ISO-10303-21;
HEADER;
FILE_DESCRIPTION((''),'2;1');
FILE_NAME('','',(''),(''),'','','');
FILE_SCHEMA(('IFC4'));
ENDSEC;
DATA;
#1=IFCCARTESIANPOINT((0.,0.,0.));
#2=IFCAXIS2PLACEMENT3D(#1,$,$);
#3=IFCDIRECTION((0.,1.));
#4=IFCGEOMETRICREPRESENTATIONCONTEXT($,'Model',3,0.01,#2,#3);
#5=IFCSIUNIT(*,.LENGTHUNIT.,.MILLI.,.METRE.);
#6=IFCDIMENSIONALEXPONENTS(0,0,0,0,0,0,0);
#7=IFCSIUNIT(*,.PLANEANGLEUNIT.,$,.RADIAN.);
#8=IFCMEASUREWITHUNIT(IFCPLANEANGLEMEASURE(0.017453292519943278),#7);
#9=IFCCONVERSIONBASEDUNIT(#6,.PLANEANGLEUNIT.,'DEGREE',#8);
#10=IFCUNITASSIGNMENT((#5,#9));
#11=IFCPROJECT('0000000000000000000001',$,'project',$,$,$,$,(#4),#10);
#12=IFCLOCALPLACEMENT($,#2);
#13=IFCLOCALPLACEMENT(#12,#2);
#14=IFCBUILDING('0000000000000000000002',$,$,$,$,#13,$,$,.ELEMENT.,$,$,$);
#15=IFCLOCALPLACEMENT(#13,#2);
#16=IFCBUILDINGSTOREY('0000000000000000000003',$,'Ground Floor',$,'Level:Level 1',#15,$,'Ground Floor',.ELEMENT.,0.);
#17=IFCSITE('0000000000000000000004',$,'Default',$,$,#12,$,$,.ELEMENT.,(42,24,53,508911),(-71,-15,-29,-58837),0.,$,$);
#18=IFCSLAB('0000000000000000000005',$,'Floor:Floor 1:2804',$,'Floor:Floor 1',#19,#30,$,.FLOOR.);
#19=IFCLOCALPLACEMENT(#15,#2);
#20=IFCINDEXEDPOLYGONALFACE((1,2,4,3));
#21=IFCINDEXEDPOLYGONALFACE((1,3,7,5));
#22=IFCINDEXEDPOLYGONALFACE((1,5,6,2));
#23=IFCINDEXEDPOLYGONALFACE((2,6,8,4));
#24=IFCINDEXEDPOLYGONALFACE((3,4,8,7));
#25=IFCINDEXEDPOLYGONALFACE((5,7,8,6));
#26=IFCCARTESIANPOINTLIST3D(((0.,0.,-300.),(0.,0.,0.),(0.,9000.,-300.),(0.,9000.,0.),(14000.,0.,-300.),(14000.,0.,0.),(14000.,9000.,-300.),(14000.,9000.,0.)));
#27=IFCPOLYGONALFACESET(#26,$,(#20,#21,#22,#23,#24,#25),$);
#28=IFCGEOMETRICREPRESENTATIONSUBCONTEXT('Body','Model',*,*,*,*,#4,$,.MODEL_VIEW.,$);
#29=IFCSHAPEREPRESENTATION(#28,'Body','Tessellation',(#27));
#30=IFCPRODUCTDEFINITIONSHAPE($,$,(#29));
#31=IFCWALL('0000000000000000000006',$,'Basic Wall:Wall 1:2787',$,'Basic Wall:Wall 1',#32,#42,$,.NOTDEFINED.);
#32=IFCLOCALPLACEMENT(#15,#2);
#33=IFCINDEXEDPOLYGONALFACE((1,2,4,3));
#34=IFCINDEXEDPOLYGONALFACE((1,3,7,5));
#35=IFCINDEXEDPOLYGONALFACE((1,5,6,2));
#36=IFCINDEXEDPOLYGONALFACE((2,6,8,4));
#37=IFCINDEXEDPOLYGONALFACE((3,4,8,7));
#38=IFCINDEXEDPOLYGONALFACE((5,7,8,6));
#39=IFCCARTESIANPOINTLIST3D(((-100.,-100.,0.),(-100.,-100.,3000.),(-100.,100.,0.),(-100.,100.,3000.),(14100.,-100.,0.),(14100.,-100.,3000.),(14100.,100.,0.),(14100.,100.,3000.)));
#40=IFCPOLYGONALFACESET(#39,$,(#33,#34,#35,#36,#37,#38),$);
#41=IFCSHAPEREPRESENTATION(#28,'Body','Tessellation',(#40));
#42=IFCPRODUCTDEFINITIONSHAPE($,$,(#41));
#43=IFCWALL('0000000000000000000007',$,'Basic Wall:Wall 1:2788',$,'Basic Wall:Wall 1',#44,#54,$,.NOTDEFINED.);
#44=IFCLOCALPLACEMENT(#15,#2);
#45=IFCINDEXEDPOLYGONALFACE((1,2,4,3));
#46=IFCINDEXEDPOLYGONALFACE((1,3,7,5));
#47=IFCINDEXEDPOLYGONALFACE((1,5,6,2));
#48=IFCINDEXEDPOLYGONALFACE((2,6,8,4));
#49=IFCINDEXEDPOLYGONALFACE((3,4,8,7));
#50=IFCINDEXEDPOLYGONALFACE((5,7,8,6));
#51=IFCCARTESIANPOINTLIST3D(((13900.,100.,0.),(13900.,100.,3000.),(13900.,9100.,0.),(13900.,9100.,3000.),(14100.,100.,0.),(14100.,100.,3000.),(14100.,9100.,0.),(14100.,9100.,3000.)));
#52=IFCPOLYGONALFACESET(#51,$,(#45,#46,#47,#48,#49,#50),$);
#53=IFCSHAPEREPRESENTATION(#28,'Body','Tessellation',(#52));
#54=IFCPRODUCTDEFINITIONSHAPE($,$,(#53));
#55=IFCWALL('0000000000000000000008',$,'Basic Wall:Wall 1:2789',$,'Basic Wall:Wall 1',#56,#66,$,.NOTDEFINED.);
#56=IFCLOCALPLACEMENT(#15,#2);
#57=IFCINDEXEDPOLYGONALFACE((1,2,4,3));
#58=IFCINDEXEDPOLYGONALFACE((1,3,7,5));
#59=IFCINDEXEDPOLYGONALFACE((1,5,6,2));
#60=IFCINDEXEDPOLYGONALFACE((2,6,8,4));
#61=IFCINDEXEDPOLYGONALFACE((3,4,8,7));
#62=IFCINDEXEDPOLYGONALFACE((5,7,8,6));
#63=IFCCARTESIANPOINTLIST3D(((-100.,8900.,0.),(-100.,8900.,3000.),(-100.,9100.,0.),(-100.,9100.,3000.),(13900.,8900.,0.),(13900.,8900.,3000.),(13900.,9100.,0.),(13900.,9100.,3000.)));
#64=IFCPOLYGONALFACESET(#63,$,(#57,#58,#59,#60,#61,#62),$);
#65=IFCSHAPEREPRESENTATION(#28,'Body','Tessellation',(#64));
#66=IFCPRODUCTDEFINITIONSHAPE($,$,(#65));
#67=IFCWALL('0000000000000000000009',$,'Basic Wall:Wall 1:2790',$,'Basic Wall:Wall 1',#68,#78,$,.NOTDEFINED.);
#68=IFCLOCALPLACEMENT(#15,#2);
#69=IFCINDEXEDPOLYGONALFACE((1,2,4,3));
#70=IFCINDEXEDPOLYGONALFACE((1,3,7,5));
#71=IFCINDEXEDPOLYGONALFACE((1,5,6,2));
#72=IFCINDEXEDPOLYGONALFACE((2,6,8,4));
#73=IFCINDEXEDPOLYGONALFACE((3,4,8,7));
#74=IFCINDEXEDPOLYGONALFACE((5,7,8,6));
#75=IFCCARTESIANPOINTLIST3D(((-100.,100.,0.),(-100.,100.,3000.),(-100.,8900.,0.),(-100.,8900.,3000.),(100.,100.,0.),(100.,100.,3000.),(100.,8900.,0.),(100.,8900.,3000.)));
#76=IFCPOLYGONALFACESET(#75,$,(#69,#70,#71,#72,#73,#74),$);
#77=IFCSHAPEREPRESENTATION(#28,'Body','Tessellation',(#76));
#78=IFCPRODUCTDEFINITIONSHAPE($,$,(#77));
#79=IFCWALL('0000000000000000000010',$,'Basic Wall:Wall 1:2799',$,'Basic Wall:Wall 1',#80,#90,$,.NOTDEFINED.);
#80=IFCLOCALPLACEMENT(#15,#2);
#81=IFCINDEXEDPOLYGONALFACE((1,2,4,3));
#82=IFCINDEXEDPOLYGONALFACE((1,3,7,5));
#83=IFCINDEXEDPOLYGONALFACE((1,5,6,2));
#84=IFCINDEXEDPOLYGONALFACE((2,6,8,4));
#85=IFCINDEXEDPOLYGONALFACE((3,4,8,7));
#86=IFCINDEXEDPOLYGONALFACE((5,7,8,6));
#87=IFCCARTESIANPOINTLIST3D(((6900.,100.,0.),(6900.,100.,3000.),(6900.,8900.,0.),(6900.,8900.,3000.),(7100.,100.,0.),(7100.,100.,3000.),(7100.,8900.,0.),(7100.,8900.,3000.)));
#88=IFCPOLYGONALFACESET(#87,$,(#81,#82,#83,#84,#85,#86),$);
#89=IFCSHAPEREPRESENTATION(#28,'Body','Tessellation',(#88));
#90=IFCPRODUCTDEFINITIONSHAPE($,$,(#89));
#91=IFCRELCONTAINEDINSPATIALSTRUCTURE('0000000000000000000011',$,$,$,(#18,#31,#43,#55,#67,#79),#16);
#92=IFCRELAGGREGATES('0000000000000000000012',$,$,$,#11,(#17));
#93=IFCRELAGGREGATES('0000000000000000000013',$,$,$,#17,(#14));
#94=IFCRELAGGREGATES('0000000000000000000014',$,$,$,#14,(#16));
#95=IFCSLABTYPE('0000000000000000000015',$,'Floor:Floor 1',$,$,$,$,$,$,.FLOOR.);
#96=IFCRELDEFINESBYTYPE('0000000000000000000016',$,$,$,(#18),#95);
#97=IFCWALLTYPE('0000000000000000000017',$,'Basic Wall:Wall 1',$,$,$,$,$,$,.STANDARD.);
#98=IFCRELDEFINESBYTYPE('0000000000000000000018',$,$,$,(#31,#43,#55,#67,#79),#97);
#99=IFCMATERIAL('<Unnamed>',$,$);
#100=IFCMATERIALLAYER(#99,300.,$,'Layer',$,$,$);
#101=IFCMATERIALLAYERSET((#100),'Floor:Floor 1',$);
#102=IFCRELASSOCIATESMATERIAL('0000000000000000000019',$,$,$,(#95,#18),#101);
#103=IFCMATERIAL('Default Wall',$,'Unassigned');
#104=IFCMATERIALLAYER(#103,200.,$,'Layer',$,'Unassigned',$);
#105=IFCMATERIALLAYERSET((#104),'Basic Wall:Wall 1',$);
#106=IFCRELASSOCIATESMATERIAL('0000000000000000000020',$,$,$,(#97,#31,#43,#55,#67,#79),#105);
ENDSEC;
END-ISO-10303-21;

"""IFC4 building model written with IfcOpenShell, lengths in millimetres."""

from ifc_helpers import new_model, entity, si_unit, converted_unit, direction, frame, frame_2d, origin, origin_2d_with_axis, place, context, subcontext, project, spatial, rectangle, extrude, material, layer, layer_set, layer_usage, type_object, element, save


model = new_model("IFC4")

# Units and contexts
model_context = context("Model", 3, precision=0.01, world=origin(), true_north=direction((0.0, 1.0)))
body_context = subcontext(model_context, "Body", "Model", "MODEL_VIEW")
ifc_project = project(units=[si_unit("LENGTHUNIT", "METRE", prefix="MILLI"), converted_unit("PLANEANGLEUNIT", "DEGREE", entity("IfcPlaneAngleMeasure", 0.017453292519943278), si_unit("PLANEANGLEUNIT", "RADIAN"), dimensions=[0, 0, 0, 0, 0, 0, 0])], contexts=[model_context])

# Site, building, storey
site_placement = place(None, origin())
site = spatial("IfcSite", under=ifc_project, at=site_placement, Name="Default", CompositionType="ELEMENT", RefLatitude=(42, 24, 53, 508911), RefLongitude=(-71, -15, -29, -58837), RefElevation=0.0)
building_placement = place(site_placement, origin())
building = spatial("IfcBuilding", under=site, at=building_placement, CompositionType="ELEMENT")
storey_placement = place(building_placement, origin())
storey = spatial("IfcBuildingStorey", under=building, at=storey_placement, Name="Ground Floor", ObjectType="Level:Level 1", LongName="Ground Floor", CompositionType="ELEMENT", Elevation=0.0)

# Slab
ifc_material_1 = material(Name="<Unnamed>")
ifc_layer_1 = layer(ifc_material_1, 300.0, Name="Layer")
ifc_layer_set_1 = layer_set([ifc_layer_1], Name="Floor:Floor 1")
ifc_layer_usage_1 = layer_usage(ifc_layer_set_1, "AXIS3", "POSITIVE", 0.0)
slab_type = type_object("IfcSlabType", Name="Floor:Floor 1", PredefinedType="FLOOR", material=ifc_layer_set_1)
slab_placement = place(storey_placement, origin())
element("IfcSlab", 1, at=slab_placement, inside=storey, type_object=slab_type, material=ifc_layer_usage_1, Name="Floor:Floor 1:2804", ObjectType="Floor:Floor 1", PredefinedType="FLOOR", context=body_context, shape_type="SweptSolid", body=[
    extrude(rectangle(XDim=9000.0, YDim=14000.0, at=origin_2d_with_axis()), frame((7000.0, 4500.0, 0.0), z_axis=(0.0, 0.0, -1.0), x_axis=(0.0, 1.0, 0.0)), (0.0, 0.0, 1.0), 300.0),
])

# Walls
ifc_material_2 = material(Name="Default Wall", Category="Unassigned")
ifc_layer_2 = layer(ifc_material_2, 200.0, Name="Layer", Category="Unassigned")
ifc_layer_set_2 = layer_set([ifc_layer_2], Name="Basic Wall:Wall 1")
ifc_layer_usage_2 = layer_usage(ifc_layer_set_2, "AXIS2", "NEGATIVE", 100.0)
wall_type = type_object("IfcWallType", Name="Basic Wall:Wall 1", PredefinedType="STANDARD", material=ifc_layer_set_2)
wall_1_placement = place(storey_placement, frame((-100.0, 0.0, 0.0)))
element("IfcWall", 2, at=wall_1_placement, inside=storey, type_object=wall_type, material=ifc_layer_usage_2, Name="Basic Wall:Wall 1:2787", ObjectType="Basic Wall:Wall 1", PredefinedType="NOTDEFINED", context=body_context, shape_type="SweptSolid", body=[
    extrude(rectangle(XDim=14200.0, YDim=200.0, at=frame_2d((7100.0, 0.0), x_axis=(-1.0, 0.0))), origin(), (0.0, 0.0, 1.0), 3000.0),
])
ifc_layer_usage_3 = layer_usage(ifc_layer_set_2, "AXIS2", "NEGATIVE", 100.0)
wall_2_placement = place(storey_placement, frame((14000.0, 100.0, 0.0), z_axis=(0.0, 0.0, 1.0), x_axis=(0.0, 1.0, 0.0)))
element("IfcWall", 3, at=wall_2_placement, inside=storey, type_object=wall_type, material=ifc_layer_usage_3, Name="Basic Wall:Wall 1:2788", ObjectType="Basic Wall:Wall 1", PredefinedType="NOTDEFINED", context=body_context, shape_type="SweptSolid", body=[
    extrude(rectangle(XDim=9000.0, YDim=200.0, at=frame_2d((4500.0, 0.0), x_axis=(-1.0, 0.0))), origin(), (0.0, 0.0, 1.0), 3000.0),
])
ifc_layer_usage_4 = layer_usage(ifc_layer_set_2, "AXIS2", "NEGATIVE", 100.0)
wall_3_placement = place(storey_placement, frame((13900.0, 9000.0, 0.0), z_axis=(0.0, 0.0, 1.0), x_axis=(-1.0, 0.0, 0.0)))
element("IfcWall", 4, at=wall_3_placement, inside=storey, type_object=wall_type, material=ifc_layer_usage_4, Name="Basic Wall:Wall 1:2789", ObjectType="Basic Wall:Wall 1", PredefinedType="NOTDEFINED", context=body_context, shape_type="SweptSolid", body=[
    extrude(rectangle(XDim=14000.0, YDim=200.0, at=frame_2d((7000.0, 0.0), x_axis=(-1.0, 0.0))), origin(), (0.0, 0.0, 1.0), 3000.0),
])
ifc_layer_usage_5 = layer_usage(ifc_layer_set_2, "AXIS2", "NEGATIVE", 100.0)
wall_4_placement = place(storey_placement, frame((0.0, 8900.0, 0.0), z_axis=(0.0, 0.0, 1.0), x_axis=(0.0, -1.0, 0.0)))
element("IfcWall", 5, at=wall_4_placement, inside=storey, type_object=wall_type, material=ifc_layer_usage_5, Name="Basic Wall:Wall 1:2790", ObjectType="Basic Wall:Wall 1", PredefinedType="NOTDEFINED", context=body_context, shape_type="SweptSolid", body=[
    extrude(rectangle(XDim=8800.0, YDim=200.0, at=frame_2d((4400.0, 0.0), x_axis=(-1.0, 0.0))), origin(), (0.0, 0.0, 1.0), 3000.0),
])
ifc_layer_usage_6 = layer_usage(ifc_layer_set_2, "AXIS2", "NEGATIVE", 100.0)
wall_5_placement = place(storey_placement, frame((7000.0, 100.0, 0.0), z_axis=(0.0, 0.0, 1.0), x_axis=(0.0, 1.0, 0.0)))
element("IfcWall", 6, at=wall_5_placement, inside=storey, type_object=wall_type, material=ifc_layer_usage_6, Name="Basic Wall:Wall 1:2799", ObjectType="Basic Wall:Wall 1", PredefinedType="NOTDEFINED", context=body_context, shape_type="SweptSolid", body=[
    extrude(rectangle(XDim=8800.0, YDim=200.0, at=frame_2d((4400.0, 0.0), x_axis=(-1.0, 0.0))), origin(), (0.0, 0.0, 1.0), 3000.0),
])

save(model, "model.ifc")
